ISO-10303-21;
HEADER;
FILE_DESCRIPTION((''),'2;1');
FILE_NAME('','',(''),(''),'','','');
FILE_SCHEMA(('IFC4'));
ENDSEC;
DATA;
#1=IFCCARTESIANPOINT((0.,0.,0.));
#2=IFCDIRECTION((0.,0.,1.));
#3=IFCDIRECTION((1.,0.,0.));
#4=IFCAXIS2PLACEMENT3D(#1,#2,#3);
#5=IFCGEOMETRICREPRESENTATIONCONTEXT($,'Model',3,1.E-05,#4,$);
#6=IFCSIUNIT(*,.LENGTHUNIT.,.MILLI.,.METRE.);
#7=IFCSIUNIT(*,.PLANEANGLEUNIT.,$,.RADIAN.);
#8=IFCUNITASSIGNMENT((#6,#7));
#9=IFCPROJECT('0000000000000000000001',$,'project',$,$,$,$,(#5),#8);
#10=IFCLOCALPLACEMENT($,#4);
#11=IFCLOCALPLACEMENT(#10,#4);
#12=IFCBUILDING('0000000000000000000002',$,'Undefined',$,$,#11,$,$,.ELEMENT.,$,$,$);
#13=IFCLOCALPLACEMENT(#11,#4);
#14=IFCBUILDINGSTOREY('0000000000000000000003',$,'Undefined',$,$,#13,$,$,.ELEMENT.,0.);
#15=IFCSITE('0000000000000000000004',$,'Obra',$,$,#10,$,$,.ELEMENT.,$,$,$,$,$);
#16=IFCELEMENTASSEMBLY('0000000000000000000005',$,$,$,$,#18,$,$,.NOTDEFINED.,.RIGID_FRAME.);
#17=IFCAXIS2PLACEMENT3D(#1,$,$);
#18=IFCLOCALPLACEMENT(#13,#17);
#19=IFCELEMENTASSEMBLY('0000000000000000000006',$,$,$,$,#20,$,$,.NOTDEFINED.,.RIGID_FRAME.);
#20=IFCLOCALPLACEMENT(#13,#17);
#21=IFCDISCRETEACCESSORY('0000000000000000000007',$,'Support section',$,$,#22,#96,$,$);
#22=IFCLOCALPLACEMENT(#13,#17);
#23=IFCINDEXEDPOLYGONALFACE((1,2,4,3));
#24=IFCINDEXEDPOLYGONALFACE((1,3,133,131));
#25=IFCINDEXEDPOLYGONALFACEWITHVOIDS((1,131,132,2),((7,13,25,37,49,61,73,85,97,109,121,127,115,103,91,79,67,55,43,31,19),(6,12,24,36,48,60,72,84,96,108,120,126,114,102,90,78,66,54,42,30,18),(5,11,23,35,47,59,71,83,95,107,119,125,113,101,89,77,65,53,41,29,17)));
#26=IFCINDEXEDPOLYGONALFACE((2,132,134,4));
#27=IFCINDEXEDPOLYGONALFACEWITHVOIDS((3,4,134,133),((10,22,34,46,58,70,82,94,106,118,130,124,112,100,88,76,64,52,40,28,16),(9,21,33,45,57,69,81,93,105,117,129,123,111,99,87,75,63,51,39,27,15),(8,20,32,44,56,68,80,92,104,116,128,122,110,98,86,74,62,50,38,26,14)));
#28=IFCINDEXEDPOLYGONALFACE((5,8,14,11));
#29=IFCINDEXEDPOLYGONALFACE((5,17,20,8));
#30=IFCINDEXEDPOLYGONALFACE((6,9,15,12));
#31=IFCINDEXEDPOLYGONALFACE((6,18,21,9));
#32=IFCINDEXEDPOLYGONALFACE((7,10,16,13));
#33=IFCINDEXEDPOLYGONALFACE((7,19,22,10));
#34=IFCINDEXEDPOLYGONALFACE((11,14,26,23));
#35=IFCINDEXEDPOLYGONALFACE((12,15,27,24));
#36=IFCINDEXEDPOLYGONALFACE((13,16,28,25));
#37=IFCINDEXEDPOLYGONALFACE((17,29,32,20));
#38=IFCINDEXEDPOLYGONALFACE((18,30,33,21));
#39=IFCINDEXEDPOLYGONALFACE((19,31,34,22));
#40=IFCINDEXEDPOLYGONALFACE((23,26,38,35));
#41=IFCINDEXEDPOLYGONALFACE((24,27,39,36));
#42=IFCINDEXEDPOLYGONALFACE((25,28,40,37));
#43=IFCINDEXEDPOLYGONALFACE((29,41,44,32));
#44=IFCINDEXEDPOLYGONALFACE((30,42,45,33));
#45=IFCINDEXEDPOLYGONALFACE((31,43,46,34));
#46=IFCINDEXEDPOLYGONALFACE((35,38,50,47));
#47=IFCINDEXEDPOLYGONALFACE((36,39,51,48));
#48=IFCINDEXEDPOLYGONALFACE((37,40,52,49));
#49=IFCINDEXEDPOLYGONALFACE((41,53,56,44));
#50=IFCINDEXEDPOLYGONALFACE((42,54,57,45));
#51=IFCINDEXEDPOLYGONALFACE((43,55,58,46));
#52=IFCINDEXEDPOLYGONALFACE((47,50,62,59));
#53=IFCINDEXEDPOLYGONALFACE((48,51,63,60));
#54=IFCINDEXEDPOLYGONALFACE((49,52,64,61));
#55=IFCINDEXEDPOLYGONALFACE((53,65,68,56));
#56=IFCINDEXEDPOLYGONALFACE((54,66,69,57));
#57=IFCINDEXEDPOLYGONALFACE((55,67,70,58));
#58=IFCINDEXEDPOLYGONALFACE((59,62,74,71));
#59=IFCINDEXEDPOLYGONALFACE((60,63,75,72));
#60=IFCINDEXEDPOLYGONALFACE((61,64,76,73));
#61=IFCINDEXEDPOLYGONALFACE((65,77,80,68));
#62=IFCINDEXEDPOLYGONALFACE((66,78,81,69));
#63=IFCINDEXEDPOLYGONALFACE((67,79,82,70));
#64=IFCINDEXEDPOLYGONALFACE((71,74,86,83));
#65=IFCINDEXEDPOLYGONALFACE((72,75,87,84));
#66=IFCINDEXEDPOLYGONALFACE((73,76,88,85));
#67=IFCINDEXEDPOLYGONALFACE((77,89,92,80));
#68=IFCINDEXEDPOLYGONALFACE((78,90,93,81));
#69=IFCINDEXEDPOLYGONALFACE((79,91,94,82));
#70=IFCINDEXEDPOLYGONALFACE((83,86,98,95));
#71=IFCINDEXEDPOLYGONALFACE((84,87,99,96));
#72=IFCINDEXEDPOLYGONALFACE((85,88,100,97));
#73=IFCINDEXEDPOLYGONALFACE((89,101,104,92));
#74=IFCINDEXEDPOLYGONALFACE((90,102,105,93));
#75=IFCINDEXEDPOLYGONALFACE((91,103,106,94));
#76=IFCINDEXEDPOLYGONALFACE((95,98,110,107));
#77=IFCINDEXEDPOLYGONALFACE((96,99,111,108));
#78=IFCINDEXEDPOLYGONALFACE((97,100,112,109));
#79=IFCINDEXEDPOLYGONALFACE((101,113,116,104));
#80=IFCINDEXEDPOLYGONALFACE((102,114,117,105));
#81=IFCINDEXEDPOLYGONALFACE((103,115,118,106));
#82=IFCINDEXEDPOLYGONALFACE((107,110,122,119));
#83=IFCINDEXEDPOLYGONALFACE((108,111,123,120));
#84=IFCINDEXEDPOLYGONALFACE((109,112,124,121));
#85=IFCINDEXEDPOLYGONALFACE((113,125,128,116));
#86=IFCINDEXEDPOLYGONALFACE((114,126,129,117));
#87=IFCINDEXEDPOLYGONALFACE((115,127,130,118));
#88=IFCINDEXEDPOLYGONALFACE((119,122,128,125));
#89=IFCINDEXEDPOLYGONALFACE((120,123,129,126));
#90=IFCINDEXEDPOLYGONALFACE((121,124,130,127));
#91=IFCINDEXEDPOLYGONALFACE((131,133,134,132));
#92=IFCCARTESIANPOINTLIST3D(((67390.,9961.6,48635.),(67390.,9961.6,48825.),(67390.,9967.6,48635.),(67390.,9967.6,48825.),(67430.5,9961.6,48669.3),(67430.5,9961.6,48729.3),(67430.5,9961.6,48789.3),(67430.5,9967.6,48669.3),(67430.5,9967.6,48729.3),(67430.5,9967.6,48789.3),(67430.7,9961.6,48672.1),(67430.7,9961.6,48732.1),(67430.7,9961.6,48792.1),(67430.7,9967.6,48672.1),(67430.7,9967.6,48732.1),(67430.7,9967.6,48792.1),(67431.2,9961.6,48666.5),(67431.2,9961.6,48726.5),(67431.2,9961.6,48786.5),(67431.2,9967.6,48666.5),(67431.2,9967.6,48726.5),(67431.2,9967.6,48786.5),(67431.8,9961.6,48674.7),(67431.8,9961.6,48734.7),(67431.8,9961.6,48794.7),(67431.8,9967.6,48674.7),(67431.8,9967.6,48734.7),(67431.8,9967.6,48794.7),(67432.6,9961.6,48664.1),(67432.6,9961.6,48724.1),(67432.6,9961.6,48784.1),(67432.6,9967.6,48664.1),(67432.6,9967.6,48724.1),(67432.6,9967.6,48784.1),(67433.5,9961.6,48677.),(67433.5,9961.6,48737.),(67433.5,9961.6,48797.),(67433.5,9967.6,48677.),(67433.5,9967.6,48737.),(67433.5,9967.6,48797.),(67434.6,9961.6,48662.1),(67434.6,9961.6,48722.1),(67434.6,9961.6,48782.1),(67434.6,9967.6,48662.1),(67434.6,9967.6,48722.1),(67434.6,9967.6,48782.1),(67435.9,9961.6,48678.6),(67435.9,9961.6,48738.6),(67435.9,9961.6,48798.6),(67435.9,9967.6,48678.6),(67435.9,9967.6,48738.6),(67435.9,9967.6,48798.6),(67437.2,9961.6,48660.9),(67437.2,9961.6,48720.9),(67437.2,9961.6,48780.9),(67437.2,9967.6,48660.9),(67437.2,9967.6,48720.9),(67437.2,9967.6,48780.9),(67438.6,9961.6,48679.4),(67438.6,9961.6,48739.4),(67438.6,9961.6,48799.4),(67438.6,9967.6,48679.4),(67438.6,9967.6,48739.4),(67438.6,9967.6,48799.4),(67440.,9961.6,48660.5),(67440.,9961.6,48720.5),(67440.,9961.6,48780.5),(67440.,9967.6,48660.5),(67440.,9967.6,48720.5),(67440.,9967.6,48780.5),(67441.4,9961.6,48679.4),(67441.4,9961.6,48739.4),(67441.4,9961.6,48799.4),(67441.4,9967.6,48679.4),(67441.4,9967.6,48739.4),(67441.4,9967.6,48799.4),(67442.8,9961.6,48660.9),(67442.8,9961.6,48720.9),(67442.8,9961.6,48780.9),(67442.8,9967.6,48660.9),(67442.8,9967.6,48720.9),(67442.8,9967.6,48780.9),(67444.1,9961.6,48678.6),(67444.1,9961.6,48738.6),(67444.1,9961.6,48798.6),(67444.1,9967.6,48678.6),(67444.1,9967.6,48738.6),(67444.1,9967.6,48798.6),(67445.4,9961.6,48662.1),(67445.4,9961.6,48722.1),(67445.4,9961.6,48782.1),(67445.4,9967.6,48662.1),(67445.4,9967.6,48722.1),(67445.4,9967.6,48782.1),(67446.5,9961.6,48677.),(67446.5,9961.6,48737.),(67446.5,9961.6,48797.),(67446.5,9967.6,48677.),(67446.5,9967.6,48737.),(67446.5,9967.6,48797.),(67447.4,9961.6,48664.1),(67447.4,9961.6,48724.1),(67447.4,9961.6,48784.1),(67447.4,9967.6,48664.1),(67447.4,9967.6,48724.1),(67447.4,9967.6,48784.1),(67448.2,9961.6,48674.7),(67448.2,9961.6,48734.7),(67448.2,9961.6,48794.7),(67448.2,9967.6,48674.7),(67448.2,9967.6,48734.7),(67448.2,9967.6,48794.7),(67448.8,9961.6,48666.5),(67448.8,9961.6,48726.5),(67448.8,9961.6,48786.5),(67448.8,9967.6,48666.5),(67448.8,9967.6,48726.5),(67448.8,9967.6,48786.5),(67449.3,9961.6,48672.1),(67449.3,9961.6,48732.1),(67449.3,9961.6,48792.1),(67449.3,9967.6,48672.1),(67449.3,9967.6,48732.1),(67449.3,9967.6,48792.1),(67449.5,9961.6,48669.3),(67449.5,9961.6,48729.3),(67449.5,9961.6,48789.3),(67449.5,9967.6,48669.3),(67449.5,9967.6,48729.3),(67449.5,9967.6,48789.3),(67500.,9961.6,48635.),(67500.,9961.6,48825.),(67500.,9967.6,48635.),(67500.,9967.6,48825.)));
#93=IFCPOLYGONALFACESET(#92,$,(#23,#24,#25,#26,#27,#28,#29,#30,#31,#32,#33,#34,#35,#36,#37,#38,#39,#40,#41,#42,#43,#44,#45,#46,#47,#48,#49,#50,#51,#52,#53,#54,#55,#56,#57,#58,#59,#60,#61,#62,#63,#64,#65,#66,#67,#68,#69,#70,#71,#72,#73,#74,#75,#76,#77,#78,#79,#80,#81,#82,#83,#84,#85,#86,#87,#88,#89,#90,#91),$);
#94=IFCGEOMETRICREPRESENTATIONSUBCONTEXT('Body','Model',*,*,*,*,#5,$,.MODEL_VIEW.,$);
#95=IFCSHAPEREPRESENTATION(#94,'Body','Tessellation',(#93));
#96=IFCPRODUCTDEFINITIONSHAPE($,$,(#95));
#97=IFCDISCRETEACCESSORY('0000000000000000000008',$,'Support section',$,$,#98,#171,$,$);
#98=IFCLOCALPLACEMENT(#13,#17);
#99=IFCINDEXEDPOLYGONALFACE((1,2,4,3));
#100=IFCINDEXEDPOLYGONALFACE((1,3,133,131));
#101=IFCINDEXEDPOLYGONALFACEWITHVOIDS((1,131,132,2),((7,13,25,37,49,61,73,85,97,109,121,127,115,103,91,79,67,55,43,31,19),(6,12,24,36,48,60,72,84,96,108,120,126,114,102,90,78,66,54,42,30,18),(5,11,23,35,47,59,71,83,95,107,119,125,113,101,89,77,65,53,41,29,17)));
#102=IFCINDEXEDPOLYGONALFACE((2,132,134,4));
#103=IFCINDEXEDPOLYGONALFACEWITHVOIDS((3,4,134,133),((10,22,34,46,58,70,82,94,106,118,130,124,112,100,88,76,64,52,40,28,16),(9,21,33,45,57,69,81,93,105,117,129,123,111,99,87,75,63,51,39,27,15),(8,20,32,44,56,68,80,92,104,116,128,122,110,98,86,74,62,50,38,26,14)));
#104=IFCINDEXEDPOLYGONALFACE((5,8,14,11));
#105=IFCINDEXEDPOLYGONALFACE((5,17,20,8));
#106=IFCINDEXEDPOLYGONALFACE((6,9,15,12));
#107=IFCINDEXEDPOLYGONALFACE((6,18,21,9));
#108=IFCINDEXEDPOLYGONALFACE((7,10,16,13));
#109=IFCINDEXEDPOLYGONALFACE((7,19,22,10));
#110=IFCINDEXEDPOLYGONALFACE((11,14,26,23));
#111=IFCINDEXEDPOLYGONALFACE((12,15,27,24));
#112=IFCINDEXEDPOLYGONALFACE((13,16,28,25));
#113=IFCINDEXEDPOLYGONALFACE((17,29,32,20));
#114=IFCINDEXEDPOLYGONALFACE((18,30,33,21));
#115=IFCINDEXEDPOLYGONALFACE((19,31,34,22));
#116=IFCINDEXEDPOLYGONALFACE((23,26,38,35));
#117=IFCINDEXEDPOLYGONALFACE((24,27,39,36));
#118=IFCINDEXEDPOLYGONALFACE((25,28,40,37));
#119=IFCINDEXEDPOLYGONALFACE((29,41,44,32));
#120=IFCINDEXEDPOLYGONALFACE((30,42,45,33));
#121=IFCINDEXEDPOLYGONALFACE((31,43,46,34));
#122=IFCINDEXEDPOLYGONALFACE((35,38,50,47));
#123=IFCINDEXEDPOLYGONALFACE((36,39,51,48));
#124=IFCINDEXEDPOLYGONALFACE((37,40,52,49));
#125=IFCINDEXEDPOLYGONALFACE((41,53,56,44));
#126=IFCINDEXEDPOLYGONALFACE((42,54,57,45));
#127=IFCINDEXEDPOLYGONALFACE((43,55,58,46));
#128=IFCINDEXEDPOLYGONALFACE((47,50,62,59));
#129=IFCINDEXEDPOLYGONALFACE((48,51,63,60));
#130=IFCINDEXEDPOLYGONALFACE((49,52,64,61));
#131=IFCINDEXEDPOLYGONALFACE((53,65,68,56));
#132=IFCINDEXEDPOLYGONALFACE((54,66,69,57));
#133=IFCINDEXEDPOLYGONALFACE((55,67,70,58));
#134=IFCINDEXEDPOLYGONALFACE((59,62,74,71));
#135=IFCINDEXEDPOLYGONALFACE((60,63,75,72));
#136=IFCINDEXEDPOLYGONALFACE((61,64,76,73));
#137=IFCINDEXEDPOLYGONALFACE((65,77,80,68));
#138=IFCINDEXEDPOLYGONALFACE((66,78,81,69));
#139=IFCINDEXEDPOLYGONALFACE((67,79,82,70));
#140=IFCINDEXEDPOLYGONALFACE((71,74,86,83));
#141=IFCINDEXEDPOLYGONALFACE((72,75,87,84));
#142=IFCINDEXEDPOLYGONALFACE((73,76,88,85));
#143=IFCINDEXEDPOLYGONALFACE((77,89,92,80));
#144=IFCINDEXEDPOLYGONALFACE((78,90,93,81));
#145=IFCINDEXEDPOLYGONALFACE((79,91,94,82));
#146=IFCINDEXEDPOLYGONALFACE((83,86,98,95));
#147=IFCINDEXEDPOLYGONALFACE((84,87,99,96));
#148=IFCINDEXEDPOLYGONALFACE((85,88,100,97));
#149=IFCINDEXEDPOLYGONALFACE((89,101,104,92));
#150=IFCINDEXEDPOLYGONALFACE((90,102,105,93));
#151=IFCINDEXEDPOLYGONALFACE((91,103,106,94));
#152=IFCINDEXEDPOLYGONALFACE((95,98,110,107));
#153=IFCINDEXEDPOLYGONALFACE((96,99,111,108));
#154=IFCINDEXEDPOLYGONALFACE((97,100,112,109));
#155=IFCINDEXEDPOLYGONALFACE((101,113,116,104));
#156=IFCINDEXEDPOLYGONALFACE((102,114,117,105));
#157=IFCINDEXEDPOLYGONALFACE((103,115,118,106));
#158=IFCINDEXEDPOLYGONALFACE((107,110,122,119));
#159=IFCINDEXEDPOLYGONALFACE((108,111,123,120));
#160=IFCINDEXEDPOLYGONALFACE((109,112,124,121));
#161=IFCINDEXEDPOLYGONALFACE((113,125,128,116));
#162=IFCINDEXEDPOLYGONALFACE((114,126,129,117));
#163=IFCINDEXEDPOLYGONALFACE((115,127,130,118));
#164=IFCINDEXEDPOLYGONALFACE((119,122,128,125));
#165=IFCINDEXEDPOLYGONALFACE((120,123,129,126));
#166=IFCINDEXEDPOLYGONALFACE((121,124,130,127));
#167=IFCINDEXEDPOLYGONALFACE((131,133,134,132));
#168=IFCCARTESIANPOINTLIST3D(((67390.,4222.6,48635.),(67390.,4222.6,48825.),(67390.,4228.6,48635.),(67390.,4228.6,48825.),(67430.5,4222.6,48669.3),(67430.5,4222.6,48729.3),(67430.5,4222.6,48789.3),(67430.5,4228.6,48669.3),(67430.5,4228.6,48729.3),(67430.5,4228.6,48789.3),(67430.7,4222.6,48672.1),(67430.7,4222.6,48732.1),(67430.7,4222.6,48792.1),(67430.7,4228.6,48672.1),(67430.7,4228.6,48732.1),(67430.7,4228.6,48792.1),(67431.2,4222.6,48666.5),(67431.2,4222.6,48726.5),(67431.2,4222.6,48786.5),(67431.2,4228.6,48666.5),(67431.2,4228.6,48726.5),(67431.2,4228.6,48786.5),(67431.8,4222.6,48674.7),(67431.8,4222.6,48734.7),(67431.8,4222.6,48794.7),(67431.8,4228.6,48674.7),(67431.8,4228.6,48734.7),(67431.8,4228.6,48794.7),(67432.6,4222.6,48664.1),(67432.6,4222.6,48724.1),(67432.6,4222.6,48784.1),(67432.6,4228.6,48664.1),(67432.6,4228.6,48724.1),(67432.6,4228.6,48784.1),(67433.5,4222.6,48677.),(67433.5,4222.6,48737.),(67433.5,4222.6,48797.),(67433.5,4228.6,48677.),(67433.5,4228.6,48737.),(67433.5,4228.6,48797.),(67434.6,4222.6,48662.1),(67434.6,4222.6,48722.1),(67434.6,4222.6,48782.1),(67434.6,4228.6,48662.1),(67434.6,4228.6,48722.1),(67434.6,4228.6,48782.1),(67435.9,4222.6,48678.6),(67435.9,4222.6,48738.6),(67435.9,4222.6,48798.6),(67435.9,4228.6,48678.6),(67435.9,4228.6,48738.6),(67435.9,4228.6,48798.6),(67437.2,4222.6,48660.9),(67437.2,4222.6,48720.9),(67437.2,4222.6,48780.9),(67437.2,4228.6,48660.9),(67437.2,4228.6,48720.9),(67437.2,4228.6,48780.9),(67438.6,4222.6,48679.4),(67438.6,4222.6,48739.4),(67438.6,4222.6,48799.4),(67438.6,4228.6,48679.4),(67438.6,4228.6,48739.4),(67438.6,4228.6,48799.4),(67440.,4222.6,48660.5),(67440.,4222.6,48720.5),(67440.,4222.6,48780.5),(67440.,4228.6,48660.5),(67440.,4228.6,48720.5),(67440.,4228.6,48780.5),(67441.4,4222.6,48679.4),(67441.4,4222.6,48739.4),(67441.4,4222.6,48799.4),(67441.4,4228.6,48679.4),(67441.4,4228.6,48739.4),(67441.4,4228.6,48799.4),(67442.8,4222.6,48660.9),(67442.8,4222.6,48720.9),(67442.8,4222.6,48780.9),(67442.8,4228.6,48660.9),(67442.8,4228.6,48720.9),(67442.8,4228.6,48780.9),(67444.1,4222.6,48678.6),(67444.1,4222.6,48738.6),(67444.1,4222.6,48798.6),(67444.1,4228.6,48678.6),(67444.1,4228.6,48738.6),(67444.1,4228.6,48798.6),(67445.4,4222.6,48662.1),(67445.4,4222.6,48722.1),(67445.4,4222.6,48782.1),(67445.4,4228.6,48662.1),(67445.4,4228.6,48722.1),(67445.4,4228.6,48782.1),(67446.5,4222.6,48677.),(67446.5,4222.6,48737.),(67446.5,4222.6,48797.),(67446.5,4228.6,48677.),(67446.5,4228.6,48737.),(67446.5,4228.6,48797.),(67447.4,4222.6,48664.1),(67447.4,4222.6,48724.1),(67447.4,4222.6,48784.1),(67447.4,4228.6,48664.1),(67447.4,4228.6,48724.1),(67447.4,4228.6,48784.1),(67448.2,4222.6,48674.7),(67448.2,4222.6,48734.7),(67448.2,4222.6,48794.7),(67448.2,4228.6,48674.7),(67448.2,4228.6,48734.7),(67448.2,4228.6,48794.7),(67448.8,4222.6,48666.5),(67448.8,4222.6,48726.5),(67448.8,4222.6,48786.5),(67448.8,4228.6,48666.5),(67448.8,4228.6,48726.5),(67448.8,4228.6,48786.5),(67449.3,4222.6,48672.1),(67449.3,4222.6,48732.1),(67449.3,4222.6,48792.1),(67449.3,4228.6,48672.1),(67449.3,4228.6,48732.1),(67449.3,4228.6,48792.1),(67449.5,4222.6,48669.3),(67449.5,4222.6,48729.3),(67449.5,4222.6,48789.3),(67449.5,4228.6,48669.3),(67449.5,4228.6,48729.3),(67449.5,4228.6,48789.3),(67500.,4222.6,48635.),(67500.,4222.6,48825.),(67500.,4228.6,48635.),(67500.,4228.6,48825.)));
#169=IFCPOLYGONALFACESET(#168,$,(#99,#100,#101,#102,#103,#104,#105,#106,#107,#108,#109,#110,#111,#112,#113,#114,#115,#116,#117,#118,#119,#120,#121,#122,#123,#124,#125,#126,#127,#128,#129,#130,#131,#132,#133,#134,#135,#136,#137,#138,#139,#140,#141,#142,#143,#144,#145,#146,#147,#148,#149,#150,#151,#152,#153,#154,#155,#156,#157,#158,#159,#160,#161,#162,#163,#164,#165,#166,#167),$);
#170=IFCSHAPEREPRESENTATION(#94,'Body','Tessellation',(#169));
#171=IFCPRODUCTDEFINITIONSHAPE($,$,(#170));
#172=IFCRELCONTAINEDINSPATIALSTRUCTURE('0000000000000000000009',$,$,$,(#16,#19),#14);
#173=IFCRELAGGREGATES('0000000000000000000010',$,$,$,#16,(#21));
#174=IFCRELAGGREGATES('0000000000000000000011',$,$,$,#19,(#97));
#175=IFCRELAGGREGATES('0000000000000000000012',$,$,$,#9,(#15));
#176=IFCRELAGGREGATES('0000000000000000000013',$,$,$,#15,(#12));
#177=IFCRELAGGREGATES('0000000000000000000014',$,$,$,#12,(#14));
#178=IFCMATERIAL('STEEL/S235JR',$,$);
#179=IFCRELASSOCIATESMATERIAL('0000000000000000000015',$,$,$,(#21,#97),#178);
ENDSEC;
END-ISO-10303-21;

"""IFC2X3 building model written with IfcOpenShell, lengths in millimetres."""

from ifc_helpers import new_model, si_unit, frame, origin_with_axes, origin_2d_with_axis, place, context, subcontext, project, spatial, rectangle, circle, extrude, source, transform, mapped, material, element, aggregate, save


model = new_model("IFC2X3")

# Units and contexts
model_context = context("Model", 3, precision=1e-05, world=origin_with_axes())
body_context = subcontext(model_context, "Body", "Model", "MODEL_VIEW")
ifc_project = project(units=[si_unit("LENGTHUNIT", "METRE", prefix="MILLI"), si_unit("PLANEANGLEUNIT", "RADIAN")], contexts=[model_context])

# Site, building, storey
site_placement = place(None, origin_with_axes())
site = spatial("IfcSite", under=ifc_project, at=site_placement, Name="Obra", CompositionType="ELEMENT")
building_placement = place(site_placement, origin_with_axes())
building = spatial("IfcBuilding", under=site, at=building_placement, Name="Undefined", CompositionType="ELEMENT")
storey_placement = place(building_placement, origin_with_axes())
storey = spatial("IfcBuildingStorey", under=building, at=storey_placement, Name="Undefined", CompositionType="ELEMENT", Elevation=0.0)

# Element assemblies
assembly_1_placement = place(storey_placement, origin_with_axes())
assembly_1 = element("IfcElementAssembly", 1, at=assembly_1_placement, inside=storey, AssemblyPlace="NOTDEFINED", PredefinedType="RIGID_FRAME")
ifc_material_1 = material(Name="STEEL/S235JR")
assembly_2_placement = place(storey_placement, origin_with_axes())
assembly_2 = element("IfcElementAssembly", 2, at=assembly_2_placement, inside=storey, AssemblyPlace="NOTDEFINED", PredefinedType="RIGID_FRAME")

# Discrete accessories, openings
discrete_accessory_1_placement = place(assembly_1_placement, frame((67445.0, 9964.6, 48635.0), z_axis=(0.0, 0.0, 1.0), x_axis=(1.0, 0.0, 0.0)))
discrete_accessory_1 = element("IfcDiscreteAccessory", 3, at=discrete_accessory_1_placement, material=ifc_material_1, Name="Support section", context=body_context, shape_type="SweptSolid", body=[
    extrude(rectangle(XDim=6.0, YDim=110.0, at=origin_2d_with_axis()), frame((0.0, 0.0, 190.0), z_axis=(0.0, 0.0, -1.0), x_axis=(0.0, 1.0, 0.0)), (0.0, 0.0, 1.0), 190.0),
])
shared_shape_1 = source(origin_with_axes(), body_context, "Body", "SweptSolid", [
    extrude(circle(Radius=9.5, at=origin_2d_with_axis()), frame((0.0, -9.2, 0.0), z_axis=(0.0, 1.0, 0.0), x_axis=(1.0, 0.0, 0.0)), (0.0, 0.0, 1.0), 6.2),
])
opening_1_placement = place(assembly_1_placement, frame((67490.0, 9958.5, 48850.0), z_axis=(-1.0, 0.0, 0.0), x_axis=(0.0, 0.0, -1.0)))
element("IfcOpeningElement", 4, at=opening_1_placement, cuts=discrete_accessory_1, ObjectType="Opening", context=body_context, shape_type="MappedRepresentation", body=[
    mapped(shared_shape_1, transform((60.0, 0.0, 50.0))),
    mapped(shared_shape_1, transform((120.0, 0.0, 50.0))),
    mapped(shared_shape_1, transform((180.0, 0.0, 50.0))),
])
aggregate(assembly_1, [discrete_accessory_1])
discrete_accessory_2_placement = place(assembly_2_placement, frame((67445.0, 4225.6, 48635.0), z_axis=(0.0, 0.0, 1.0), x_axis=(1.0, 0.0, 0.0)))
discrete_accessory_2 = element("IfcDiscreteAccessory", 5, at=discrete_accessory_2_placement, material=ifc_material_1, Name="Support section", context=body_context, shape_type="SweptSolid", body=[
    extrude(rectangle(XDim=6.0, YDim=110.0, at=origin_2d_with_axis()), frame((0.0, 0.0, 190.0), z_axis=(0.0, 0.0, -1.0), x_axis=(0.0, 1.0, 0.0)), (0.0, 0.0, 1.0), 190.0),
])
opening_2_placement = place(assembly_2_placement, frame((67490.0, 4219.5, 48850.0), z_axis=(-1.0, 0.0, 0.0), x_axis=(0.0, 0.0, -1.0)))
element("IfcOpeningElement", 6, at=opening_2_placement, cuts=discrete_accessory_2, ObjectType="Opening", context=body_context, shape_type="MappedRepresentation", body=[
    mapped(shared_shape_1, transform((60.0, 0.0, 50.0))),
    mapped(shared_shape_1, transform((120.0, 0.0, 50.0))),
    mapped(shared_shape_1, transform((180.0, 0.0, 50.0))),
])
aggregate(assembly_2, [discrete_accessory_2])

save(model, "model.ifc")
